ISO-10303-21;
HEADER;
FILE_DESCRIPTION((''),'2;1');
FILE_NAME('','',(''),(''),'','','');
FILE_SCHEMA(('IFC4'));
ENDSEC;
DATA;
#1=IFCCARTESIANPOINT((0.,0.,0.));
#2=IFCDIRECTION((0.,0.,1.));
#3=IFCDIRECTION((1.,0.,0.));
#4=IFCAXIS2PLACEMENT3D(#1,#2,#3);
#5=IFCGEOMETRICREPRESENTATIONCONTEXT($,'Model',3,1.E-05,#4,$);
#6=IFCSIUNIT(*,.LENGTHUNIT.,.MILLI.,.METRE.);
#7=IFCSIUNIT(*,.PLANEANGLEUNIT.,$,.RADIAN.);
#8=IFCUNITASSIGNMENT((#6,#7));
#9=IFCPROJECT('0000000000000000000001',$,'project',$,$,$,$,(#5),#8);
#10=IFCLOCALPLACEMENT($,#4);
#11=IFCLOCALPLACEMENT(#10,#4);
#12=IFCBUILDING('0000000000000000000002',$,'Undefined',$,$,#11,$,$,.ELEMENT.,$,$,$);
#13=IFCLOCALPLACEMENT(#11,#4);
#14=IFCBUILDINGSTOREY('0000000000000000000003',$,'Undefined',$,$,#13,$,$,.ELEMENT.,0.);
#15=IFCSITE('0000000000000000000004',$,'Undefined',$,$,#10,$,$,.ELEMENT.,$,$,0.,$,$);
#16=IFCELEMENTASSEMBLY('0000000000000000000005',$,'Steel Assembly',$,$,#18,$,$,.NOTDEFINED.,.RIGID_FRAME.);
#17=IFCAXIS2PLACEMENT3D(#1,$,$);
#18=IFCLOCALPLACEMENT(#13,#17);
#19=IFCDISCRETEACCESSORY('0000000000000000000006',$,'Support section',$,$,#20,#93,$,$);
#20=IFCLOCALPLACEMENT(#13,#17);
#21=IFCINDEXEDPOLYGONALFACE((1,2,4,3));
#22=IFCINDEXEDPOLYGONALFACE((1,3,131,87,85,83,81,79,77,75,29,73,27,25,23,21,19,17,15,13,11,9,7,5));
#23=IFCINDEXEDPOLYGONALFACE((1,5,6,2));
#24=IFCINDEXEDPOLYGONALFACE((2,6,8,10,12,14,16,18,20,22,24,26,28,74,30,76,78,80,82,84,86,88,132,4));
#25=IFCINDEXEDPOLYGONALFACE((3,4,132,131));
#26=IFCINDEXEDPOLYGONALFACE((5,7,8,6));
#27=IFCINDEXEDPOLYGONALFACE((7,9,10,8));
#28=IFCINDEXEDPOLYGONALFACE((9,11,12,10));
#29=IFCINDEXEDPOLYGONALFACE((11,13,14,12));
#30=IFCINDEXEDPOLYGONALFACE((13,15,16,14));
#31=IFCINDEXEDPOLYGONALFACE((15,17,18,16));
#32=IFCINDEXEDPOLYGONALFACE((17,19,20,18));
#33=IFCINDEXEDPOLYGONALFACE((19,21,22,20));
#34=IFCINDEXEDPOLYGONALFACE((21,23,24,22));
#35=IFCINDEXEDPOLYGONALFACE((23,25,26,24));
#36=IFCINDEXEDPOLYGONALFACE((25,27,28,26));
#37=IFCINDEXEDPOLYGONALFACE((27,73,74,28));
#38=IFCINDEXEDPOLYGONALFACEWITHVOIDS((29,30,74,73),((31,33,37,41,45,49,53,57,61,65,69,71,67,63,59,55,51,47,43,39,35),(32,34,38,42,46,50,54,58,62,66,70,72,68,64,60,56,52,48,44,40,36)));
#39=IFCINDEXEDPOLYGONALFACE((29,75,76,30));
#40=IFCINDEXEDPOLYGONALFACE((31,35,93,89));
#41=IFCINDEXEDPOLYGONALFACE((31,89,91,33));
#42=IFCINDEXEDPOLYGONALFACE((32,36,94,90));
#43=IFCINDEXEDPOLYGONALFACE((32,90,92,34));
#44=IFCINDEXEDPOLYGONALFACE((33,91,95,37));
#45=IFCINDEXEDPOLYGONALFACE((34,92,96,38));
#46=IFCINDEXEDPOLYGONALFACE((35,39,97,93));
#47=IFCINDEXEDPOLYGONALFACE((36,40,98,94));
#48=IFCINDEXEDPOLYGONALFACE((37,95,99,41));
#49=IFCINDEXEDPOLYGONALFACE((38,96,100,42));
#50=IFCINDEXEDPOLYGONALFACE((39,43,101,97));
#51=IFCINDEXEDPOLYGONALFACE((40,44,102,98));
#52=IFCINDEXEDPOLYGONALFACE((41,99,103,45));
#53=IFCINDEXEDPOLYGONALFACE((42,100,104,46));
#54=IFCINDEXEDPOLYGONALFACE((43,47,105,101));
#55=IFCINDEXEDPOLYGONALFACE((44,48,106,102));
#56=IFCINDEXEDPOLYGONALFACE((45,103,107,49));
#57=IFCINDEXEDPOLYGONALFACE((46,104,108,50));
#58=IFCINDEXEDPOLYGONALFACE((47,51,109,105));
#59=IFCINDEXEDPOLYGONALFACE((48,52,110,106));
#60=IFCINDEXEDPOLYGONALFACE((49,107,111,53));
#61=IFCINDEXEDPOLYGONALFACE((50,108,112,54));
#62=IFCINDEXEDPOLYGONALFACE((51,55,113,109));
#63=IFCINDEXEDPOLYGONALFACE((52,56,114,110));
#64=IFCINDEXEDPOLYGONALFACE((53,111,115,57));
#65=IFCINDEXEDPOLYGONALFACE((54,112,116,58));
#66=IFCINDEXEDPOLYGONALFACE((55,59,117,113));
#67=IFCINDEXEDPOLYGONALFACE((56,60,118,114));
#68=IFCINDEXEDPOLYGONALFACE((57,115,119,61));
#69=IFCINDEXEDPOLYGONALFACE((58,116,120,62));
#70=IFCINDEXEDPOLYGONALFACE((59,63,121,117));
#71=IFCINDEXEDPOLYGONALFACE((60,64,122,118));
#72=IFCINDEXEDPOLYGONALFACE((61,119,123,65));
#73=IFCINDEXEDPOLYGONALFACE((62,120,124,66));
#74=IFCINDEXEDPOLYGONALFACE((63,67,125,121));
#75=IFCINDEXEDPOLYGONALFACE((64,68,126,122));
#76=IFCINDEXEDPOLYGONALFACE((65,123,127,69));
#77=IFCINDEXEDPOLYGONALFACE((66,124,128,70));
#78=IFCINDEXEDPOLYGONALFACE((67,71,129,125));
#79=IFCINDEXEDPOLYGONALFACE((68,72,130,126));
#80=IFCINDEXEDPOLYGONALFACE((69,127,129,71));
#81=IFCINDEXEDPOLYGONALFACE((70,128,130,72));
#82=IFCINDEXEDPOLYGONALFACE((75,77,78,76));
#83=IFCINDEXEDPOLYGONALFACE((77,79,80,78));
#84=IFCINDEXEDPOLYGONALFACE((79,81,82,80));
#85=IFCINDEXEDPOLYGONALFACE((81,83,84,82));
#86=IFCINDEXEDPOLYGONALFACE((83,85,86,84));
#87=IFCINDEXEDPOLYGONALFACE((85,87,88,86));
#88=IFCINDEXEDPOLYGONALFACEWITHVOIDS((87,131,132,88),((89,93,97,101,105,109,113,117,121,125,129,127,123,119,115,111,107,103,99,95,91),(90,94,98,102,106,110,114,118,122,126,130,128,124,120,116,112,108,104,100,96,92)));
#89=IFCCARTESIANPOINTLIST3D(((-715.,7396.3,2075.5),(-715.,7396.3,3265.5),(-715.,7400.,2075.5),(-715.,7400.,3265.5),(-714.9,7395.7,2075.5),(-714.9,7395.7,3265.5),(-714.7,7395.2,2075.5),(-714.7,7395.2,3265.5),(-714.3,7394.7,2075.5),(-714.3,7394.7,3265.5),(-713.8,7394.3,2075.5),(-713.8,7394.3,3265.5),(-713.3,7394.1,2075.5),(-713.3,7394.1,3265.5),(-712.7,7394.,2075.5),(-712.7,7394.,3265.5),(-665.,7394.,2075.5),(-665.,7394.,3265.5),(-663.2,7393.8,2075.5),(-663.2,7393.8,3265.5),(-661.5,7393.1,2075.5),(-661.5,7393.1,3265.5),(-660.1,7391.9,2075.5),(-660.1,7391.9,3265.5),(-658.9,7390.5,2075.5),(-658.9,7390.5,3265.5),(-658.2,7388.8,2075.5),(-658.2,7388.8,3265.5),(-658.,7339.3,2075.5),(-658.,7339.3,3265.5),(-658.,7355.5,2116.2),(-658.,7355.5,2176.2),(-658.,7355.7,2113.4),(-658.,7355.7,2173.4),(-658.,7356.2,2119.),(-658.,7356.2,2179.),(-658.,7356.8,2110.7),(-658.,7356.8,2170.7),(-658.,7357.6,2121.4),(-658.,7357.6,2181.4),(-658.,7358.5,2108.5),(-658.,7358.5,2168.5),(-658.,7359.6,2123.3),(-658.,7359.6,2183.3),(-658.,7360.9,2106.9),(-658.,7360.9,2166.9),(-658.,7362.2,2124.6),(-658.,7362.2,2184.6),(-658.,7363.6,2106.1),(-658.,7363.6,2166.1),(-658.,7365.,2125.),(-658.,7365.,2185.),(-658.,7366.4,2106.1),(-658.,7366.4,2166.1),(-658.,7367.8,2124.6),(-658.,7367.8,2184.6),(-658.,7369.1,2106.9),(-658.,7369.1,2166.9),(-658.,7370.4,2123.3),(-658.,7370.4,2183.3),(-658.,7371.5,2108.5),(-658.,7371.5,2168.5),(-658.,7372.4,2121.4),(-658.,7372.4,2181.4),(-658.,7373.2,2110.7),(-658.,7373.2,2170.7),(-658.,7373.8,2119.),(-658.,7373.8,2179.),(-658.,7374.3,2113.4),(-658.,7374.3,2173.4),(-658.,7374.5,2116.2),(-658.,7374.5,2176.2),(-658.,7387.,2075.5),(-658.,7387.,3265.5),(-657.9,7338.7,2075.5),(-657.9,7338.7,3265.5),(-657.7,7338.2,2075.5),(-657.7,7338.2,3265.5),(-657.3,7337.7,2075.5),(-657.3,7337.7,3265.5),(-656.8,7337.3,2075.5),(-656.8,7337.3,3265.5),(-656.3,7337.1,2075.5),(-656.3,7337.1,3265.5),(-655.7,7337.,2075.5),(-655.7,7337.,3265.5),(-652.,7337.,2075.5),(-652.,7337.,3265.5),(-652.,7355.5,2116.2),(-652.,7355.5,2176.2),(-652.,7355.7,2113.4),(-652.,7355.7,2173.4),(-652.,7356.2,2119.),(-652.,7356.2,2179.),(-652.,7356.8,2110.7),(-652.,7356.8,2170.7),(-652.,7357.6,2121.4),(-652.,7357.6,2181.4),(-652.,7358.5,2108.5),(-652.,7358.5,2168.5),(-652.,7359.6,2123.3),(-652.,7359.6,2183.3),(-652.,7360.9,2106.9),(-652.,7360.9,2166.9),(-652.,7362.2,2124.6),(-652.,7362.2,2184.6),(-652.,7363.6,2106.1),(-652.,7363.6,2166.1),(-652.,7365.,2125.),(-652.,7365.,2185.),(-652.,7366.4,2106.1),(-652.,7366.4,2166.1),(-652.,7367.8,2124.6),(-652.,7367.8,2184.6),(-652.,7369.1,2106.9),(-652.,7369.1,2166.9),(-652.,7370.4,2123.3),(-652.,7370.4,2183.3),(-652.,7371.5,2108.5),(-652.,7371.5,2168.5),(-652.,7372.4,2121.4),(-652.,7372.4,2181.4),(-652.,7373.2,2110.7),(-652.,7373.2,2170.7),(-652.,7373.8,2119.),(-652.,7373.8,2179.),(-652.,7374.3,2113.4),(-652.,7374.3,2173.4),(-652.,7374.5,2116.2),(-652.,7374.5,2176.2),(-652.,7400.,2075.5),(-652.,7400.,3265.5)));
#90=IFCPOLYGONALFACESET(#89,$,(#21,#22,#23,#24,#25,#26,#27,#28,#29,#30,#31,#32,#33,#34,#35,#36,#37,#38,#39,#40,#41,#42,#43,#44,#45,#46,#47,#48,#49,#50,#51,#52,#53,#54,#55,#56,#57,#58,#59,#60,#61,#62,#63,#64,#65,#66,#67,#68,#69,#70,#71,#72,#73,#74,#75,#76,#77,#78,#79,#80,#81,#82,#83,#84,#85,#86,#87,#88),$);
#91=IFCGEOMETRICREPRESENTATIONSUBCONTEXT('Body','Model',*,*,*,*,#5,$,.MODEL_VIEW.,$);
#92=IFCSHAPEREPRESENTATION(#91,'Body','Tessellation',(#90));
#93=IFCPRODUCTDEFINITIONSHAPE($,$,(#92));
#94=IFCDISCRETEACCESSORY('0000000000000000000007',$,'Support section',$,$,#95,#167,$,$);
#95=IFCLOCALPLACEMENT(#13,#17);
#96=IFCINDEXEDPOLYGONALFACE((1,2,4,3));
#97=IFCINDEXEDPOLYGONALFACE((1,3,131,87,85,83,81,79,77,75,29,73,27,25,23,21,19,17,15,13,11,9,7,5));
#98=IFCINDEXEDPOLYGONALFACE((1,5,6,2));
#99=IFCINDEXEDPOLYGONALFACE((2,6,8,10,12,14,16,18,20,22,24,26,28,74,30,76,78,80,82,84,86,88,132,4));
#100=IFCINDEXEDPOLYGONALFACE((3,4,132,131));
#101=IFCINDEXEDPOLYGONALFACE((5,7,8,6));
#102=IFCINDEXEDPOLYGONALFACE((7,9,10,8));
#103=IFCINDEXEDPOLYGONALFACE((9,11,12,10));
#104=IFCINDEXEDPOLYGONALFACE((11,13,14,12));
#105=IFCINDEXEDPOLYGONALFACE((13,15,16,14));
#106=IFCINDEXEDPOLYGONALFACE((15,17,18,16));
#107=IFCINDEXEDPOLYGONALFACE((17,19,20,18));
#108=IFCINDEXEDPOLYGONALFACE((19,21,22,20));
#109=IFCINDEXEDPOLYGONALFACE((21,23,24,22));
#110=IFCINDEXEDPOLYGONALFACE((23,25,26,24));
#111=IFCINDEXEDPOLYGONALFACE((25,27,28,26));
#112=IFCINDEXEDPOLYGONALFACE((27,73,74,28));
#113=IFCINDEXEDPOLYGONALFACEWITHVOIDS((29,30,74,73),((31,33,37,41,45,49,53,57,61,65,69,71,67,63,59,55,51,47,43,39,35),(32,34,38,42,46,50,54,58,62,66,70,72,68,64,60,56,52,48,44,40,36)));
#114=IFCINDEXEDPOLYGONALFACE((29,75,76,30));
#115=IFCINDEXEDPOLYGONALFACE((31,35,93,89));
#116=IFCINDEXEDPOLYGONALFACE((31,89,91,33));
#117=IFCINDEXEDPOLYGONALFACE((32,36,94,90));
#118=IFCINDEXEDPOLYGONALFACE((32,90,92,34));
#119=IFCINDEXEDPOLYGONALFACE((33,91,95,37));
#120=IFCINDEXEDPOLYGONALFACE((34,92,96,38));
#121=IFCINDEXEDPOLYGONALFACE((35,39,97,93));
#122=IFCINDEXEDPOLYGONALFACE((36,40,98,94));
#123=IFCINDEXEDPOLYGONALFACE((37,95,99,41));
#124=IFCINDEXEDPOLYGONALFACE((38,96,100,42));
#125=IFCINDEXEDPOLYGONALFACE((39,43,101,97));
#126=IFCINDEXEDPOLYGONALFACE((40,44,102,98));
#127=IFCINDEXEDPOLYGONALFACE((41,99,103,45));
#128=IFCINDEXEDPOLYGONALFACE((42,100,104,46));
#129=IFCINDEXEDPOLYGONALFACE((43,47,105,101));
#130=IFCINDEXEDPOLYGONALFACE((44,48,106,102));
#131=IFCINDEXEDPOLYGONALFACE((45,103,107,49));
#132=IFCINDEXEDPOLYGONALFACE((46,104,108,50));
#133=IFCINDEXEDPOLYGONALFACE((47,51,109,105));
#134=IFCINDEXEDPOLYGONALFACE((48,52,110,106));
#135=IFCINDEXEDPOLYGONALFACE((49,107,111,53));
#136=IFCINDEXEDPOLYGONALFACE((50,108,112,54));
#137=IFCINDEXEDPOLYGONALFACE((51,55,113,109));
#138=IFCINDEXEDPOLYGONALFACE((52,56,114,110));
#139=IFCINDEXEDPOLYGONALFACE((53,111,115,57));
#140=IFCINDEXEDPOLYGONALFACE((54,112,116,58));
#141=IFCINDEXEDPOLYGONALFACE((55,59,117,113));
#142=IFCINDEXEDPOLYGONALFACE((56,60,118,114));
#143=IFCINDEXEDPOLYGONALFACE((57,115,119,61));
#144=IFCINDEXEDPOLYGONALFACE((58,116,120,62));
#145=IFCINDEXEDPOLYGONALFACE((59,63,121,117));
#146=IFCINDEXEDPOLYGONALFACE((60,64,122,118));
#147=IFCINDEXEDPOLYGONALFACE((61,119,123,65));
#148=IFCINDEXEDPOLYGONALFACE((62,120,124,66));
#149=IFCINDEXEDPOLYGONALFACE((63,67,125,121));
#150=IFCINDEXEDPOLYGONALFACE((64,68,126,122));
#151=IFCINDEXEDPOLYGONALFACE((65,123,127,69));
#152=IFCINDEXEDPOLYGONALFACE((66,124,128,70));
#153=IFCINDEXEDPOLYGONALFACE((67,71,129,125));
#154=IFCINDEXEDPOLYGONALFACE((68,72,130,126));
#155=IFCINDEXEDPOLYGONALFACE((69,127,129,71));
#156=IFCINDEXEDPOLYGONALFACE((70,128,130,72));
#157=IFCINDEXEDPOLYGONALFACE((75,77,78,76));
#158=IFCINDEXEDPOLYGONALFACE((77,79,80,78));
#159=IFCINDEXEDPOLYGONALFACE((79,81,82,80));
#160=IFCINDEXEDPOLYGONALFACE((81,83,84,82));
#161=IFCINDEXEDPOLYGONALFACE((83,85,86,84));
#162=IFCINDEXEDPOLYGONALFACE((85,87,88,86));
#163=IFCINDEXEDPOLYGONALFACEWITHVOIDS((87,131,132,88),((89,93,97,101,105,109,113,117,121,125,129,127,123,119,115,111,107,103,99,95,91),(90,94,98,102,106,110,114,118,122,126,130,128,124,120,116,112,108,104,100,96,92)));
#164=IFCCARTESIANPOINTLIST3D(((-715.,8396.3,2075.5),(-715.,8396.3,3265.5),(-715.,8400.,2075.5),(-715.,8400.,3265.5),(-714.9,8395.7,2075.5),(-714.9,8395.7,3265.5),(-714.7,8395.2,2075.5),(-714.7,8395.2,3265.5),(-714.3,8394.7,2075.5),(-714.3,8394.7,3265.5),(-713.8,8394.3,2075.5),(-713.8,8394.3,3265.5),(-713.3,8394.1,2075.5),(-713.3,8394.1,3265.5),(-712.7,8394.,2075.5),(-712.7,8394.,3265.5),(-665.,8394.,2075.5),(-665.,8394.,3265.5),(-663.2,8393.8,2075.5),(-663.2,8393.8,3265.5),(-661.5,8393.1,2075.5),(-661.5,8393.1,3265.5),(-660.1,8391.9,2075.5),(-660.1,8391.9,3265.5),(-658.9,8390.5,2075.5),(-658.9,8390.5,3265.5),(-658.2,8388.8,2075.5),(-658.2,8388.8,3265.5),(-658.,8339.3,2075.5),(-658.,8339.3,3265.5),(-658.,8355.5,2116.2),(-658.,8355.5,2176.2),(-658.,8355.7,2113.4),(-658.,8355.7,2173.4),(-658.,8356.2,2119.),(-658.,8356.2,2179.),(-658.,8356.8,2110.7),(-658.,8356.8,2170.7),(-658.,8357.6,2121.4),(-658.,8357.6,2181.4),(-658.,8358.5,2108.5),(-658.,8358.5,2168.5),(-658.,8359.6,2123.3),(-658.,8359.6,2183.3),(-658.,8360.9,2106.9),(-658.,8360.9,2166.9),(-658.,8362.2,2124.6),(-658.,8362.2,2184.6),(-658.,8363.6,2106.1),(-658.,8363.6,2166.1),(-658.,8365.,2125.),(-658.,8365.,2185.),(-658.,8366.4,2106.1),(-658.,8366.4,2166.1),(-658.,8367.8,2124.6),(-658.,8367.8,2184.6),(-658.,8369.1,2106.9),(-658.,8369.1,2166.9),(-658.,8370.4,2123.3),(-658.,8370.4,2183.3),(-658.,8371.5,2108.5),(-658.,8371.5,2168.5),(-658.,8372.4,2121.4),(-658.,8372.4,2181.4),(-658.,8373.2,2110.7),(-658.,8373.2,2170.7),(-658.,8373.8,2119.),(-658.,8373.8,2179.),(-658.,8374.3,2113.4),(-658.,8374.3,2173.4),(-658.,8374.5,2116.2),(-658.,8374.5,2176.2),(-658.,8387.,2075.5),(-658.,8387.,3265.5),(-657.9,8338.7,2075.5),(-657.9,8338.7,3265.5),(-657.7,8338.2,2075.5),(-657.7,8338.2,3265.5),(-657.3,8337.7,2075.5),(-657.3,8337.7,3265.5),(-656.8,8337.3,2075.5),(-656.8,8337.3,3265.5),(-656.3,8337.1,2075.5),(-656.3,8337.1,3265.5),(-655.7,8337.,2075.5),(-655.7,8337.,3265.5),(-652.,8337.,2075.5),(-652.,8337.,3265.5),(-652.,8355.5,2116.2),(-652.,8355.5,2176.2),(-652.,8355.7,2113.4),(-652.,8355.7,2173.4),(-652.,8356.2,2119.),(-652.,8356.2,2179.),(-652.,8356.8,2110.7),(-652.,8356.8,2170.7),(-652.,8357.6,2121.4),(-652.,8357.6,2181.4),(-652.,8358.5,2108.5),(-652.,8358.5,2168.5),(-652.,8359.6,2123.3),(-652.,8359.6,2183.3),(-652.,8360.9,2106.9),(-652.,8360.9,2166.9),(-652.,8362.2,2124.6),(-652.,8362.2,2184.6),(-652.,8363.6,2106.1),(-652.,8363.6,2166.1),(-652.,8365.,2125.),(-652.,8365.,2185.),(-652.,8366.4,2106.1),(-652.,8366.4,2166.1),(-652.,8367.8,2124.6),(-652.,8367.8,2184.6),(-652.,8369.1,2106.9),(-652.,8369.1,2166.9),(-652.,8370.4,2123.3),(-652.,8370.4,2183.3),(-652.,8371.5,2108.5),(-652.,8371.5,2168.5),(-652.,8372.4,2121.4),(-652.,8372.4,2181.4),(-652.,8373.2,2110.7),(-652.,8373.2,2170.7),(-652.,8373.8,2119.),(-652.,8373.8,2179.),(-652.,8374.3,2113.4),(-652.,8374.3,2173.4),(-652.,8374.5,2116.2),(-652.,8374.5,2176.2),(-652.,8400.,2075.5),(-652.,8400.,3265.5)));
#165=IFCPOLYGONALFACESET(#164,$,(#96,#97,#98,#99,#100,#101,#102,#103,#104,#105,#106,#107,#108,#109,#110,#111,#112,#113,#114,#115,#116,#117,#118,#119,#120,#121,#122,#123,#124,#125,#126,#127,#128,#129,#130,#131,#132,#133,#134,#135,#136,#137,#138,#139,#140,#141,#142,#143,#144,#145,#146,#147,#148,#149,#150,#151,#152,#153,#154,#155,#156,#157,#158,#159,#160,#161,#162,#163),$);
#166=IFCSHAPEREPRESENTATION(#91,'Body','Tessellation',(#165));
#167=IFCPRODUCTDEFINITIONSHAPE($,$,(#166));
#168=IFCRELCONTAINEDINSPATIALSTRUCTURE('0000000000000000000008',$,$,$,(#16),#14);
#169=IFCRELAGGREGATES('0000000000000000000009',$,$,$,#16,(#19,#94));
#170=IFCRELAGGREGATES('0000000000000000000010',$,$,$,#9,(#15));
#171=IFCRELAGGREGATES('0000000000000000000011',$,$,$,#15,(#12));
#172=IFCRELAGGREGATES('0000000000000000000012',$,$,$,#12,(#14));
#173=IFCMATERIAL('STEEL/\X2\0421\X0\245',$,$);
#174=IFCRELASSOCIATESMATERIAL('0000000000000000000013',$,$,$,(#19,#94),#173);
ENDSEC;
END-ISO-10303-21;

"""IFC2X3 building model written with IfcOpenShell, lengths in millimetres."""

from ifc_helpers import new_model, si_unit, frame, origin_with_axes, origin_2d_with_axis, place, context, subcontext, project, spatial, circle, l_section, extrude, source, transform, mapped, material, element, aggregate, save


model = new_model("IFC2X3")

# Units and contexts
model_context = context("Model", 3, precision=1e-05, world=origin_with_axes())
body_context = subcontext(model_context, "Body", "Model", "MODEL_VIEW")
ifc_project = project(units=[si_unit("LENGTHUNIT", "METRE", prefix="MILLI"), si_unit("PLANEANGLEUNIT", "RADIAN")], contexts=[model_context])

# Site, building, storey
site_placement = place(None, origin_with_axes())
site = spatial("IfcSite", under=ifc_project, at=site_placement, Name="Undefined", CompositionType="ELEMENT", RefElevation=0.0)
building_placement = place(site_placement, origin_with_axes())
building = spatial("IfcBuilding", under=site, at=building_placement, Name="Undefined", CompositionType="ELEMENT")
storey_placement = place(building_placement, origin_with_axes())
storey = spatial("IfcBuildingStorey", under=building, at=storey_placement, Name="Undefined", CompositionType="ELEMENT", Elevation=0.0)

# Shared definitions
ifc_material_1 = material(Name="STEEL/С245")

# Element assembly, discrete accessories, openings
assembly_1_placement = place(storey_placement, origin_with_axes())
assembly_1 = element("IfcElementAssembly", 1, at=assembly_1_placement, inside=storey, Name="Steel Assembly", AssemblyPlace="NOTDEFINED", PredefinedType="RIGID_FRAME")
discrete_accessory_1_placement = place(assembly_1_placement, frame((-683.5, 7368.5, 2075.5), z_axis=(0.0, 0.0, 1.0), x_axis=(1.0, 0.0, 0.0)))
discrete_accessory_1 = element("IfcDiscreteAccessory", 2, at=discrete_accessory_1_placement, material=ifc_material_1, Name="Support section", context=body_context, shape_type="SweptSolid", body=[
    extrude(l_section(Depth=63.0, Width=63.0, Thickness=6.0, FilletRadius=7.0, EdgeRadius=2.3, at=origin_2d_with_axis()), frame((0.0, 0.0, 1190.0), z_axis=(0.0, 0.0, -1.0), x_axis=(0.0, -1.0, 0.0)), (0.0, 0.0, 1.0), 1190.0),
])
shared_shape_1 = source(origin_with_axes(), body_context, "Body", "SweptSolid", [
    extrude(circle(Radius=9.5, at=origin_2d_with_axis()), frame((0.0, -0.1, 0.0), z_axis=(0.0, 1.0, 0.0), x_axis=(1.0, 0.0, 0.0)), (0.0, 0.0, 1.0), 6.2),
])
opening_1_placement = place(assembly_1_placement, frame((-652.0, 7365.0, 2115.5), z_axis=(0.0, -1.0, 0.0), x_axis=(0.0, 0.0, 1.0)))
element("IfcOpeningElement", 3, at=opening_1_placement, cuts=discrete_accessory_1, ObjectType="Opening", context=body_context, shape_type="MappedRepresentation", body=[
    mapped(shared_shape_1, transform((0.0, 0.0, 0.0))),
    mapped(shared_shape_1, transform((60.0, 0.0, 0.0))),
])
discrete_accessory_2_placement = place(assembly_1_placement, frame((-683.5, 8368.5, 2075.5), z_axis=(0.0, 0.0, 1.0), x_axis=(1.0, 0.0, 0.0)))
discrete_accessory_2 = element("IfcDiscreteAccessory", 4, at=discrete_accessory_2_placement, material=ifc_material_1, Name="Support section", context=body_context, shape_type="SweptSolid", body=[
    extrude(l_section(Depth=63.0, Width=63.0, Thickness=6.0, FilletRadius=7.0, EdgeRadius=2.3, at=origin_2d_with_axis()), frame((0.0, 0.0, 1190.0), z_axis=(0.0, 0.0, -1.0), x_axis=(0.0, -1.0, 0.0)), (0.0, 0.0, 1.0), 1190.0),
])
opening_2_placement = place(assembly_1_placement, frame((-652.0, 8365.0, 2115.5), z_axis=(0.0, -1.0, 0.0), x_axis=(0.0, 0.0, 1.0)))
element("IfcOpeningElement", 5, at=opening_2_placement, cuts=discrete_accessory_2, ObjectType="Opening", context=body_context, shape_type="MappedRepresentation", body=[
    mapped(shared_shape_1, transform((0.0, 0.0, 0.0))),
    mapped(shared_shape_1, transform((60.0, 0.0, 0.0))),
])
aggregate(assembly_1, [discrete_accessory_1, discrete_accessory_2])

save(model, "model.ifc")
